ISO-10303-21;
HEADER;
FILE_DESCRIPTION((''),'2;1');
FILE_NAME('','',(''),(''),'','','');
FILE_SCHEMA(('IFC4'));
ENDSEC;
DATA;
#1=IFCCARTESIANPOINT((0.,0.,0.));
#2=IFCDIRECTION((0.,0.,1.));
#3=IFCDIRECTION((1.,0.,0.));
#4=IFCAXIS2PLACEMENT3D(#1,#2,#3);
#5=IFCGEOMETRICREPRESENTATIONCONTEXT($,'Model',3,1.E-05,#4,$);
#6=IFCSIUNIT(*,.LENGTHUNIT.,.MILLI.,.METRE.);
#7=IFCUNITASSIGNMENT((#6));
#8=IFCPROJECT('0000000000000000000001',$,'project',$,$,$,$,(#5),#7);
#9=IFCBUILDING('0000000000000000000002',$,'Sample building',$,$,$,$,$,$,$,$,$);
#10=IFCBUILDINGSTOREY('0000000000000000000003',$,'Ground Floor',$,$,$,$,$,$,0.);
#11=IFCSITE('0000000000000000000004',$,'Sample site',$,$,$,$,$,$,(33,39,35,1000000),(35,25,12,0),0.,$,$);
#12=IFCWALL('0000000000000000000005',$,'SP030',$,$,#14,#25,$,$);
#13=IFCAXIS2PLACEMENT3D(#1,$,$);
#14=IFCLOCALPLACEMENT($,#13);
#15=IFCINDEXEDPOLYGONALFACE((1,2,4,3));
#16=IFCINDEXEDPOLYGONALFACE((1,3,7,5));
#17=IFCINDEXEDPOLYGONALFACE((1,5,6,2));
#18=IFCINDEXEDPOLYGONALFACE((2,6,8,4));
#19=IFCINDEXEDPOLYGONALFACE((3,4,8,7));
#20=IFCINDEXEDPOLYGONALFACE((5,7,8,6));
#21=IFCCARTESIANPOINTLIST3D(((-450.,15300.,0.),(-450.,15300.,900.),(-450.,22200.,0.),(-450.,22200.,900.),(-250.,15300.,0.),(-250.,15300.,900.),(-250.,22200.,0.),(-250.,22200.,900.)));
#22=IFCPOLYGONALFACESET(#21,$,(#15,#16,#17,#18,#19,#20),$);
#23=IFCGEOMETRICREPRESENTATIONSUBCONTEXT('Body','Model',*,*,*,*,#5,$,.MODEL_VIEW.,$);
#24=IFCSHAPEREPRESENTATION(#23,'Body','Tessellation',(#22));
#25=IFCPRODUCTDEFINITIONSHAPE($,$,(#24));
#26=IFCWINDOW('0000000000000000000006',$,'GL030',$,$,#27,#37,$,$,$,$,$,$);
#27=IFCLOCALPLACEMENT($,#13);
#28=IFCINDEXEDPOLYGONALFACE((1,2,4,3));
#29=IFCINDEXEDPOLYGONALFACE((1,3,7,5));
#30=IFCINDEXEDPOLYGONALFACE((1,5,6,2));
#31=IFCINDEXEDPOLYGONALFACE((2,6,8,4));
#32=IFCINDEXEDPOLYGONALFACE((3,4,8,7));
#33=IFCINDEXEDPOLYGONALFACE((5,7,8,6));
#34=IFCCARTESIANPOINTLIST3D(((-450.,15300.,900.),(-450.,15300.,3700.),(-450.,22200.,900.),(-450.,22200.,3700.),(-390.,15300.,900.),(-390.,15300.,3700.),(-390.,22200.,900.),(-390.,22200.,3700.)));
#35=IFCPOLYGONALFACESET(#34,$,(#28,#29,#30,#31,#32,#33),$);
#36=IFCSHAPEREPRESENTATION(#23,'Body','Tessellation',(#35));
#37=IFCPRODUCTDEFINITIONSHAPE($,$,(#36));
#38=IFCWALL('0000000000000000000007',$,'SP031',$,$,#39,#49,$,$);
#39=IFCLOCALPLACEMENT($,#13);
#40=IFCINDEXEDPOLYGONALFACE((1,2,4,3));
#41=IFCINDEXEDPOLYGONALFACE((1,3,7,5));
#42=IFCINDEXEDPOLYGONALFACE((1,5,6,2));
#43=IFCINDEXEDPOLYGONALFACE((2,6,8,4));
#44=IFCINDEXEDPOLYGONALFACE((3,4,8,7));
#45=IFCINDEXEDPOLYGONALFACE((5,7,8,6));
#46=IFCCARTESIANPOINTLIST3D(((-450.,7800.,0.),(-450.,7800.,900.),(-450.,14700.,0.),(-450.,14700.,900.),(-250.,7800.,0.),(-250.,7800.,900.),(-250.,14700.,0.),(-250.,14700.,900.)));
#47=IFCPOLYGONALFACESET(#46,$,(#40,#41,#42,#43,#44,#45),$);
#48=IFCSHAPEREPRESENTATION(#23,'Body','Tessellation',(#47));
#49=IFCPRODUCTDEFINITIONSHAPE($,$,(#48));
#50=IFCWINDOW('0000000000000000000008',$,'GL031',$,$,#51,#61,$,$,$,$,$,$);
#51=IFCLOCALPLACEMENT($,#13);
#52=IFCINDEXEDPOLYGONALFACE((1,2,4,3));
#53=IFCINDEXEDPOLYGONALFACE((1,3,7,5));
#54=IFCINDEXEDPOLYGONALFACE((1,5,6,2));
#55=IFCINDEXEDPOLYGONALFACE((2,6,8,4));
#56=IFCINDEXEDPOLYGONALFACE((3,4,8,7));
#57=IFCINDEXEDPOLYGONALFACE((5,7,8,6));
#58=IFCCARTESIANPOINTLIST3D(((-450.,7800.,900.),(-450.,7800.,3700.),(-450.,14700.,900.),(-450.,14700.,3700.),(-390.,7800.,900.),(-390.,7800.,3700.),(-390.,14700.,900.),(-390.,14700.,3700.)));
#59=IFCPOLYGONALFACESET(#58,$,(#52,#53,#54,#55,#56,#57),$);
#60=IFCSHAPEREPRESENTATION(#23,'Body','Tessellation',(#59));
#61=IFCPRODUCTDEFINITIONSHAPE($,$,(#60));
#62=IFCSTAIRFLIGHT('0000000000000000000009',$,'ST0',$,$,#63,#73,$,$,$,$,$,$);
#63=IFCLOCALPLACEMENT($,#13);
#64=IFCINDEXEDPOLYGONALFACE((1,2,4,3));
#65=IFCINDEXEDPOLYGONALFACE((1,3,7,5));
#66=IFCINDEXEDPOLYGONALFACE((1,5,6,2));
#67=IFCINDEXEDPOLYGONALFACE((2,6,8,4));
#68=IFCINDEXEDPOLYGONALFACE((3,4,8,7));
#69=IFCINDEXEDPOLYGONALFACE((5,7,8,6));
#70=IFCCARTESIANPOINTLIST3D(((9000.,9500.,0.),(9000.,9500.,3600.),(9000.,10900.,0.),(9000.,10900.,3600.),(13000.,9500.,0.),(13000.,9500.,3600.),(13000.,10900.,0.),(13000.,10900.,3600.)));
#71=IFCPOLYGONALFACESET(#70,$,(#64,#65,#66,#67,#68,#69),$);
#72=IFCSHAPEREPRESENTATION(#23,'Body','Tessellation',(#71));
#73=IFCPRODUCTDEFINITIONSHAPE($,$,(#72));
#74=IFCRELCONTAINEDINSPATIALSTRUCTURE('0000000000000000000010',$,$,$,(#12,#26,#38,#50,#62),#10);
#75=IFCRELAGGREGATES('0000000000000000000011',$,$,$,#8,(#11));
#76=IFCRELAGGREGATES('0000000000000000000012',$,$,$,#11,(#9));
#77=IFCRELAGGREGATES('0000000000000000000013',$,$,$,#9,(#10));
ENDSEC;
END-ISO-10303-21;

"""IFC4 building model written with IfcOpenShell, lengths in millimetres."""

from ifc_helpers import new_model, si_unit, frame, origin_with_axes, place, context, subcontext, project, spatial, indexed_curve, outline, extrude, element, save


model = new_model("IFC4")

# Units and contexts
model_context = context("Model", 3, precision=1e-05, world=origin_with_axes())
body_context = subcontext(model_context, "Body", "Model", "MODEL_VIEW")
ifc_project = project(units=[si_unit("LENGTHUNIT", "METRE", prefix="MILLI")], contexts=[model_context])

# Site, building, storey
site = spatial("IfcSite", under=ifc_project, Name="Sample site", RefLatitude=(33, 39, 35, 1000000), RefLongitude=(35, 25, 12, 0), RefElevation=0.0)
building = spatial("IfcBuilding", under=site, Name="Sample building")
storey = spatial("IfcBuildingStorey", under=building, Name="Ground Floor", Elevation=0.0)

# Wall
wall_1_placement = place(None, frame((-450.0, 22200.0, 0.0), z_axis=(0.0, 0.0, 1.0), x_axis=(0.0, -1.0, 0.0)))
element("IfcWall", 1, at=wall_1_placement, inside=storey, Name="SP030", context=body_context, shape_type="SweptSolid", body=[
    extrude(outline(indexed_curve([(0.0, 0.0), (0.0, 200.0), (6900.0, 200.0), (6900.0, 0.0), (0.0, 0.0)], self_intersect=False)), origin_with_axes(), (0.0, 0.0, 1.0), 900.0),
])

# Window
window_1_placement = place(None, frame((-450.0, 22200.0, 900.0), z_axis=(0.0, 0.0, 1.0), x_axis=(0.0, -1.0, 0.0)))
element("IfcWindow", 2, at=window_1_placement, inside=storey, Name="GL030", context=body_context, shape_type="SweptSolid", body=[
    extrude(outline(indexed_curve([(0.0, 0.0), (0.0, 60.0), (6900.0, 60.0), (6900.0, 0.0), (0.0, 0.0)], self_intersect=False)), origin_with_axes(), (0.0, 0.0, 1.0), 2800.0),
])

# Wall
wall_2_placement = place(None, frame((-450.0, 14700.0, 0.0), z_axis=(0.0, 0.0, 1.0), x_axis=(0.0, -1.0, 0.0)))
element("IfcWall", 3, at=wall_2_placement, inside=storey, Name="SP031", context=body_context, shape_type="SweptSolid", body=[
    extrude(outline(indexed_curve([(0.0, 0.0), (0.0, 200.0), (6900.0, 200.0), (6900.0, 0.0), (0.0, 0.0)], self_intersect=False)), origin_with_axes(), (0.0, 0.0, 1.0), 900.0),
])

# Window
window_2_placement = place(None, frame((-450.0, 14700.0, 900.0), z_axis=(0.0, 0.0, 1.0), x_axis=(0.0, -1.0, 0.0)))
element("IfcWindow", 4, at=window_2_placement, inside=storey, Name="GL031", context=body_context, shape_type="SweptSolid", body=[
    extrude(outline(indexed_curve([(0.0, 0.0), (0.0, 60.0), (6900.0, 60.0), (6900.0, 0.0), (0.0, 0.0)], self_intersect=False)), origin_with_axes(), (0.0, 0.0, 1.0), 2800.0),
])

# Stair flight
stair_flight_placement = place(None, frame((9000.0, 9500.0, 0.0), z_axis=(0.0, 0.0, 1.0), x_axis=(1.0, 0.0, 0.0)))
element("IfcStairFlight", 5, at=stair_flight_placement, inside=storey, Name="ST0", context=body_context, shape_type="SweptSolid", body=[
    extrude(outline(indexed_curve([(0.0, 0.0), (0.0, 1400.0), (4000.0, 1400.0), (4000.0, 0.0), (0.0, 0.0)], self_intersect=False)), origin_with_axes(), (0.0, 0.0, 1.0), 3600.0),
])

save(model, "model.ifc")
